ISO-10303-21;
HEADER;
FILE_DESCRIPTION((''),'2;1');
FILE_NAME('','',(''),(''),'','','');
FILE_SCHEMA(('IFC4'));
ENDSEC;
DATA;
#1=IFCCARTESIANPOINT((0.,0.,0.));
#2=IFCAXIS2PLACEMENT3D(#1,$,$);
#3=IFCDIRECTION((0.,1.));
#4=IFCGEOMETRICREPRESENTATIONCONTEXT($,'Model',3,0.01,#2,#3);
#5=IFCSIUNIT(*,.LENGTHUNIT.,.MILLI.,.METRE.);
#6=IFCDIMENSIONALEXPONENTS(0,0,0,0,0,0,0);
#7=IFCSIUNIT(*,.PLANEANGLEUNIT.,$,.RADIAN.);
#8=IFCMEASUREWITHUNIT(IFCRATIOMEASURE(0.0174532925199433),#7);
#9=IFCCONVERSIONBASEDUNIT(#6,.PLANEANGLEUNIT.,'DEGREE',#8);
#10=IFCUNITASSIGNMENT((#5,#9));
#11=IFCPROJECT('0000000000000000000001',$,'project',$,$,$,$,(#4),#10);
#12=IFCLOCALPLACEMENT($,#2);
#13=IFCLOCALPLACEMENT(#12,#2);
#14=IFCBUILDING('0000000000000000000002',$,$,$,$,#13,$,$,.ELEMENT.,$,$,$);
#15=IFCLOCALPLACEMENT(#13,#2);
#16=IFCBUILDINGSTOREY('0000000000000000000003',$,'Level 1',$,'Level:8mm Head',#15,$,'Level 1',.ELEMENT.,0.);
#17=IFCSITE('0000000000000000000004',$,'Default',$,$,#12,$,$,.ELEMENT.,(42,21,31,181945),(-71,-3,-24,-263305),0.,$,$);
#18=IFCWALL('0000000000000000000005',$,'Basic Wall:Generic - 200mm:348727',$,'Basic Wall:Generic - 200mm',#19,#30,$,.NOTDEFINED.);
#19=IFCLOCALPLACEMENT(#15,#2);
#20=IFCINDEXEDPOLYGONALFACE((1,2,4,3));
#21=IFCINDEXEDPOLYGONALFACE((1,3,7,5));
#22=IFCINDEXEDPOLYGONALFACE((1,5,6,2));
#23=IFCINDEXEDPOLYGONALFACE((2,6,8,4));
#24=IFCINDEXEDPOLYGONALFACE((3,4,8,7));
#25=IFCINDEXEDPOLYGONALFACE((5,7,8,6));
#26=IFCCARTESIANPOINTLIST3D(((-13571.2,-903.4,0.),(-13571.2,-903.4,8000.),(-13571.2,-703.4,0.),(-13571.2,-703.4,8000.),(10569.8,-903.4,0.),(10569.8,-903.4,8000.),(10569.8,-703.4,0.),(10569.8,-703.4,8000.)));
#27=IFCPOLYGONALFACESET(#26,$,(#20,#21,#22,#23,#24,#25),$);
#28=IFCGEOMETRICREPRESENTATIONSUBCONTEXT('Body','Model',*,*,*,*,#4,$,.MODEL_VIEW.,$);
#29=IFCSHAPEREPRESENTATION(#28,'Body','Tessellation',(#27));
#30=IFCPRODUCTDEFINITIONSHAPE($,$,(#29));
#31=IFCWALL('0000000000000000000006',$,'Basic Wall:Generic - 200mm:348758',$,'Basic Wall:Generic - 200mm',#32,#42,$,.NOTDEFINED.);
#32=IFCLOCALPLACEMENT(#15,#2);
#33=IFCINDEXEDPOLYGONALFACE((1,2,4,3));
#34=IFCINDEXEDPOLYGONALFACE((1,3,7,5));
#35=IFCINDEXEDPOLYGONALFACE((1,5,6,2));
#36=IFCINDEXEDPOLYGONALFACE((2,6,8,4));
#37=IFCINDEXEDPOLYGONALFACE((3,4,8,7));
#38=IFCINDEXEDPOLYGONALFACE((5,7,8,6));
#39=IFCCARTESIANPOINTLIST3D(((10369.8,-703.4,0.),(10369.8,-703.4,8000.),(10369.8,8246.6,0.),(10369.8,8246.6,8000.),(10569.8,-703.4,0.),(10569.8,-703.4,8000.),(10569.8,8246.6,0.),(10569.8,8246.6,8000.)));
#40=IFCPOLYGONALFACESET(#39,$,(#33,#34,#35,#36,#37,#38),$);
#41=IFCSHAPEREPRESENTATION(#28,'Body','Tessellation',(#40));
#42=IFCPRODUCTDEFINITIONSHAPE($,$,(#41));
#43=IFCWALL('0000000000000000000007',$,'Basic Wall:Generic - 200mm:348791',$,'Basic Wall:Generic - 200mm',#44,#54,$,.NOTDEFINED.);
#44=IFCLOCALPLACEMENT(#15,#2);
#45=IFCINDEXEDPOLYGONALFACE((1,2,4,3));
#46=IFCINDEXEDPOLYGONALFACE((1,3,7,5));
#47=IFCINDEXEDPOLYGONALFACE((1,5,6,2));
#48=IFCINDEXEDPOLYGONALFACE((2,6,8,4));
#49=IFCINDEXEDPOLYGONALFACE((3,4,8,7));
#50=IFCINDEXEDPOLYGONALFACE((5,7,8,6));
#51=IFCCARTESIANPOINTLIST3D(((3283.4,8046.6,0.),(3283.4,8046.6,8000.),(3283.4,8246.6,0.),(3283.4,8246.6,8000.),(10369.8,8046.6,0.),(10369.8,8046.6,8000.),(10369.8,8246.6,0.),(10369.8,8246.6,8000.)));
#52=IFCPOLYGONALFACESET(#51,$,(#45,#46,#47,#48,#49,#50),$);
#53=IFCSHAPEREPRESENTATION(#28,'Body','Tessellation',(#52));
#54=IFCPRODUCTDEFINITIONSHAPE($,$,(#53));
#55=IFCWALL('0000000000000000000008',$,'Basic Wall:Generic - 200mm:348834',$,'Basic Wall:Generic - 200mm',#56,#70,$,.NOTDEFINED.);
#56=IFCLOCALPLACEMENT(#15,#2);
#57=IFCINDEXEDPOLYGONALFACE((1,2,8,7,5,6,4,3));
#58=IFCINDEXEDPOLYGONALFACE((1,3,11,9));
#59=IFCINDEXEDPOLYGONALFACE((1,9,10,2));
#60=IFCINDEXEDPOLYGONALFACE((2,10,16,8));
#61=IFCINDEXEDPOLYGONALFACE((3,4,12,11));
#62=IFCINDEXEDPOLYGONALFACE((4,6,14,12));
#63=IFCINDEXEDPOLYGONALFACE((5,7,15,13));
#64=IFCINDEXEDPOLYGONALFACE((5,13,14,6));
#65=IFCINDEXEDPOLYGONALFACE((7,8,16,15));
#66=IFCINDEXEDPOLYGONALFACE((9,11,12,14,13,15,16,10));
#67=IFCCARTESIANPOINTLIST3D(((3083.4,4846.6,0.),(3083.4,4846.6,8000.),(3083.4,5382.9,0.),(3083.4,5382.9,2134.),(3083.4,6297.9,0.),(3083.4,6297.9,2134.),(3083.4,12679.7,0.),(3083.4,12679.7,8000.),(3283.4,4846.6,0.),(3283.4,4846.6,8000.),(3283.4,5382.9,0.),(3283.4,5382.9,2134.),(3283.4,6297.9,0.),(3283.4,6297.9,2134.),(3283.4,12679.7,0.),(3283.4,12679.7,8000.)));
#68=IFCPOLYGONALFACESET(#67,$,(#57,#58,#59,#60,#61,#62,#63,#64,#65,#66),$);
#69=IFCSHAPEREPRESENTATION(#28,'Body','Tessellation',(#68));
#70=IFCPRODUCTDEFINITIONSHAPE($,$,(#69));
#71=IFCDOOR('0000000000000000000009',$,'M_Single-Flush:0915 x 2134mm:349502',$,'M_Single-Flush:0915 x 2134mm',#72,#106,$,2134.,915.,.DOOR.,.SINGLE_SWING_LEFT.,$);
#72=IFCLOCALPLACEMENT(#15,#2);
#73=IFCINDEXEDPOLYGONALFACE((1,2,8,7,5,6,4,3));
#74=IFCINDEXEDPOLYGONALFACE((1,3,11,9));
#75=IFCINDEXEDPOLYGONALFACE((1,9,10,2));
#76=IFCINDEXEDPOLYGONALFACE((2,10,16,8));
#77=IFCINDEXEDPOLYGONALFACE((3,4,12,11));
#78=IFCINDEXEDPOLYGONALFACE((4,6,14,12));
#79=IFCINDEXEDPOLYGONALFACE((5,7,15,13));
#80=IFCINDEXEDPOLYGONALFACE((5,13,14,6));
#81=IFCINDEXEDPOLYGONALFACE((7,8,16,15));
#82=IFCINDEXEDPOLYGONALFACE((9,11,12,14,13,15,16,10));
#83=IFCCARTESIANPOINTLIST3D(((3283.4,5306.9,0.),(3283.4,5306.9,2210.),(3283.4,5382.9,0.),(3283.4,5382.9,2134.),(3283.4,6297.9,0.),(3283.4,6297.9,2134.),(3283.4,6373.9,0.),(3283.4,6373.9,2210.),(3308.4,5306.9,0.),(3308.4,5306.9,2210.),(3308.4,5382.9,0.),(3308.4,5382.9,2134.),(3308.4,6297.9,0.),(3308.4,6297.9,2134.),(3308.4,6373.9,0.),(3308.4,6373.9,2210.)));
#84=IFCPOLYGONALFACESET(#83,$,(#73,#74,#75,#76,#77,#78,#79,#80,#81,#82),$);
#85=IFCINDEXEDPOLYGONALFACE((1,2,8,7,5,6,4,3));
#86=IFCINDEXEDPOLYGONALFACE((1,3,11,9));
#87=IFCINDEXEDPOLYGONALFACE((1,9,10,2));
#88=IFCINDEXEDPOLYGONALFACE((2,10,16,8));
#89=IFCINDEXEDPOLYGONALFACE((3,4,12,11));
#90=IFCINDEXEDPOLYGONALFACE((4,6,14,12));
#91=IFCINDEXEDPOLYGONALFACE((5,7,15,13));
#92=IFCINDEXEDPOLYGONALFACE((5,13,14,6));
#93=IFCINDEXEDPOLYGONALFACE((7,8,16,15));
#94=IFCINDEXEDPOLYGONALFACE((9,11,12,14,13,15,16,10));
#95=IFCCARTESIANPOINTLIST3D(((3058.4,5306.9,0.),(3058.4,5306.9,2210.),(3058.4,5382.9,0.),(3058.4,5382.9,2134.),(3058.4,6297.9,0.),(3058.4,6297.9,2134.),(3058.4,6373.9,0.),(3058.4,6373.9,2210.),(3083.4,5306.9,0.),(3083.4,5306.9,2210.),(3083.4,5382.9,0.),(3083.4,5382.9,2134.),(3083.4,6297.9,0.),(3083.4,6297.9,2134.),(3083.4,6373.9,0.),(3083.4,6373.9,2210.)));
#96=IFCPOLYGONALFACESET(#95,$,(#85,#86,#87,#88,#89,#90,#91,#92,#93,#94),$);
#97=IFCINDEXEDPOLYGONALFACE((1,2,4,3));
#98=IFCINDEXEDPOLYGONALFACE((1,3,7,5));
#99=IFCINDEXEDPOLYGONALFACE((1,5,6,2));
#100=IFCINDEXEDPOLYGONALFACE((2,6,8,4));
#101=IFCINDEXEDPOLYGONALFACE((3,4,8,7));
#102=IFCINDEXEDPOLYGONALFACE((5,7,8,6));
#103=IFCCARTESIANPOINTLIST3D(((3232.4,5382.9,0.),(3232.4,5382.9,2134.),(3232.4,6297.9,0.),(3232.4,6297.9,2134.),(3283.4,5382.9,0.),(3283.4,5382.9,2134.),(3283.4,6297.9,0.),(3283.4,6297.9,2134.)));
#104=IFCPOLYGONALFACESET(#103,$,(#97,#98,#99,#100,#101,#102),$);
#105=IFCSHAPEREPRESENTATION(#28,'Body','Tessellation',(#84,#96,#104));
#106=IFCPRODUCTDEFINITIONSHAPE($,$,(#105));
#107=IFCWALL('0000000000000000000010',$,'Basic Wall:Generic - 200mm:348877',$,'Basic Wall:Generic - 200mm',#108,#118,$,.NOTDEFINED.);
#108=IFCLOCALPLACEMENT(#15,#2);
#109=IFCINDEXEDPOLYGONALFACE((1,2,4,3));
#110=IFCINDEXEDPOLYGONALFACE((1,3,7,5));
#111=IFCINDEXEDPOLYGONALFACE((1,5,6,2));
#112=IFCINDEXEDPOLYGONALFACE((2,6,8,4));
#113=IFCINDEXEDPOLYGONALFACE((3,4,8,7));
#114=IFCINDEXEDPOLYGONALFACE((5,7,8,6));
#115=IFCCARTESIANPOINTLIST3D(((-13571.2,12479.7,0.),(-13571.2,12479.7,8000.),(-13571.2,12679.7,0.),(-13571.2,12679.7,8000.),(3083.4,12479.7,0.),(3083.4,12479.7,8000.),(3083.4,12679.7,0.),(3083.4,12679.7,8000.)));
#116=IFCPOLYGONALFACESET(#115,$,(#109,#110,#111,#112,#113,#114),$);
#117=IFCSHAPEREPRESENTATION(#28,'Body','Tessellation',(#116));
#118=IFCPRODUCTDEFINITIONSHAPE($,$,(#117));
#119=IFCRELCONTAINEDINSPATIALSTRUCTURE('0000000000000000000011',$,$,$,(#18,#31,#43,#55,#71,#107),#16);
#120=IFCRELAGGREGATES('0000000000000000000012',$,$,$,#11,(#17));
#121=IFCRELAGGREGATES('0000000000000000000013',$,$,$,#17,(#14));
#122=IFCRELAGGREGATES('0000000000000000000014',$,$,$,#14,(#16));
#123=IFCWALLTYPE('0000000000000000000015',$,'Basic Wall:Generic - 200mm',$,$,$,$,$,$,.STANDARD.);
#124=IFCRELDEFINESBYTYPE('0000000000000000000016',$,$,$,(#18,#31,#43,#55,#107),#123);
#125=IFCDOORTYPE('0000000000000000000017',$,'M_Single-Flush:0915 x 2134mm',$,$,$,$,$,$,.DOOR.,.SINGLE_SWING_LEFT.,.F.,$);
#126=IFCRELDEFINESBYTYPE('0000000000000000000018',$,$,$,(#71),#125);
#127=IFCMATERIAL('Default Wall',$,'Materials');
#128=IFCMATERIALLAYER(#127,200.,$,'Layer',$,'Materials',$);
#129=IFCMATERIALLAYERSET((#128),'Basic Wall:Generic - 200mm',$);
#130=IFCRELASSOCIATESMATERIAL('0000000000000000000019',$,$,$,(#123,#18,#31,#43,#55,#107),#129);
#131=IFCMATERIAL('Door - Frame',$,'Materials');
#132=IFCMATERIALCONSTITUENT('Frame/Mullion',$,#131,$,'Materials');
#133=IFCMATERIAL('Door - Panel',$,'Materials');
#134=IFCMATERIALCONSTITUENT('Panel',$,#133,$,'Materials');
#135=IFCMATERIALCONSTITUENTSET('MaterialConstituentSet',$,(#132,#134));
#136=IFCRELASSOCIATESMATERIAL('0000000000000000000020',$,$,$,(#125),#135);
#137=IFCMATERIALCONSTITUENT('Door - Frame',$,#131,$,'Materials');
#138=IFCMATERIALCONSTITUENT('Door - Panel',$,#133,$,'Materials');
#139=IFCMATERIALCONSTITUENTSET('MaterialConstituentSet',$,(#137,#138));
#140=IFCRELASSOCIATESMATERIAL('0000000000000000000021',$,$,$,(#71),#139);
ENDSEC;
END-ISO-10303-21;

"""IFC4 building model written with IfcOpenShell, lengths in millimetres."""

from ifc_helpers import new_model, entity, si_unit, converted_unit, direction, frame, frame_2d, origin, place, context, subcontext, project, spatial, polyline, rectangle, outline, extrude, source, transform, mapped, material, layer, layer_set, layer_usage, constituent, constituent_set, type_object, type_shapes, element, fill, save


model = new_model("IFC4")

# Units and contexts
model_context = context("Model", 3, precision=0.01, world=origin(), true_north=direction((0.0, 1.0)))
body_context = subcontext(model_context, "Body", "Model", "MODEL_VIEW")
ifc_project = project(units=[si_unit("LENGTHUNIT", "METRE", prefix="MILLI"), converted_unit("PLANEANGLEUNIT", "DEGREE", entity("IfcRatioMeasure", 0.0174532925199433), si_unit("PLANEANGLEUNIT", "RADIAN"), dimensions=[0, 0, 0, 0, 0, 0, 0])], contexts=[model_context])

# Site, building, storey
site_placement = place(None, origin())
site = spatial("IfcSite", under=ifc_project, at=site_placement, Name="Default", CompositionType="ELEMENT", RefLatitude=(42, 21, 31, 181945), RefLongitude=(-71, -3, -24, -263305), RefElevation=0.0)
building_placement = place(site_placement, origin())
building = spatial("IfcBuilding", under=site, at=building_placement, CompositionType="ELEMENT")
storey_placement = place(building_placement, origin())
storey = spatial("IfcBuildingStorey", under=building, at=storey_placement, Name="Level 1", ObjectType="Level:8mm Head", LongName="Level 1", CompositionType="ELEMENT", Elevation=0.0)

# Walls
ifc_material_1 = material(Name="Default Wall", Category="Materials")
ifc_layer = layer(ifc_material_1, 200.0, Name="Layer", Category="Materials")
ifc_layer_set = layer_set([ifc_layer], Name="Basic Wall:Generic - 200mm")
ifc_layer_usage_1 = layer_usage(ifc_layer_set, "AXIS2", "NEGATIVE", 100.0)
wall_type = type_object("IfcWallType", Name="Basic Wall:Generic - 200mm", PredefinedType="STANDARD", material=ifc_layer_set)
wall_1_placement = place(storey_placement, frame((-13571.2, -803.4, 0.0)))
element("IfcWall", 1, at=wall_1_placement, inside=storey, type_object=wall_type, material=ifc_layer_usage_1, Name="Basic Wall:Generic - 200mm:348727", ObjectType="Basic Wall:Generic - 200mm", PredefinedType="NOTDEFINED", context=body_context, shape_type="SweptSolid", body=[
    extrude(rectangle(XDim=24141.0, YDim=200.0, at=frame_2d((12070.5, 0.0), x_axis=(-1.0, 0.0))), origin(), (0.0, 0.0, 1.0), 8000.0),
])
ifc_layer_usage_2 = layer_usage(ifc_layer_set, "AXIS2", "NEGATIVE", 100.0)
wall_2_placement = place(storey_placement, frame((10469.8, -703.4, 0.0), z_axis=(0.0, 0.0, 1.0), x_axis=(0.0, 1.0, 0.0)))
element("IfcWall", 2, at=wall_2_placement, inside=storey, type_object=wall_type, material=ifc_layer_usage_2, Name="Basic Wall:Generic - 200mm:348758", ObjectType="Basic Wall:Generic - 200mm", PredefinedType="NOTDEFINED", context=body_context, shape_type="SweptSolid", body=[
    extrude(rectangle(XDim=8950.0, YDim=200.0, at=frame_2d((4475.0, 0.0), x_axis=(-1.0, 0.0))), origin(), (0.0, 0.0, 1.0), 8000.0),
])
ifc_layer_usage_3 = layer_usage(ifc_layer_set, "AXIS2", "NEGATIVE", 100.0)
wall_3_placement = place(storey_placement, frame((10369.8, 8146.6, 0.0), z_axis=(0.0, 0.0, 1.0), x_axis=(-1.0, 0.0, 0.0)))
element("IfcWall", 3, at=wall_3_placement, inside=storey, type_object=wall_type, material=ifc_layer_usage_3, Name="Basic Wall:Generic - 200mm:348791", ObjectType="Basic Wall:Generic - 200mm", PredefinedType="NOTDEFINED", context=body_context, shape_type="SweptSolid", body=[
    extrude(rectangle(XDim=7086.4, YDim=200.0, at=frame_2d((3543.2, 0.0), x_axis=(-1.0, 0.0))), origin(), (0.0, 0.0, 1.0), 8000.0),
])

# Wall, opening, door
ifc_layer_usage_4 = layer_usage(ifc_layer_set, "AXIS2", "NEGATIVE", 100.0)
wall_4_placement = place(storey_placement, frame((3183.4, 4846.6, 0.0), z_axis=(0.0, 0.0, 1.0), x_axis=(0.0, 1.0, 0.0)))
wall_4 = element("IfcWall", 4, at=wall_4_placement, inside=storey, type_object=wall_type, material=ifc_layer_usage_4, Name="Basic Wall:Generic - 200mm:348834", ObjectType="Basic Wall:Generic - 200mm", PredefinedType="NOTDEFINED", context=body_context, shape_type="SweptSolid", body=[
    extrude(rectangle(XDim=7833.1, YDim=200.0, at=frame_2d((3916.6, 0.0), x_axis=(-1.0, 0.0))), origin(), (0.0, 0.0, 1.0), 8000.0),
])
opening_1_placement = place(wall_4_placement, frame((1451.3, 100.0, 0.0)))
opening_1 = element("IfcOpeningElement", 5, at=opening_1_placement, cuts=wall_4, PredefinedType="OPENING", context=body_context, shape_type="SweptSolid", body=[
    extrude(rectangle(XDim=915.0, YDim=2134.0, at=frame_2d((1067.0, 457.5), x_axis=(0.0, -1.0))), frame((0.0, 0.0, 0.0), z_axis=(0.0, -1.0, 0.0), x_axis=(0.0, 0.0, 1.0)), (0.0, 0.0, 1.0), 200.0),
])
ifc_material_2 = material(Name="Door - Frame", Category="Materials")
ifc_constituent_1 = constituent(ifc_material_2, Name="Door - Frame", Category="Materials")
ifc_material_3 = material(Name="Door - Panel", Category="Materials")
ifc_constituent_2 = constituent(ifc_material_3, Name="Door - Panel", Category="Materials")
ifc_constituent_set_1 = constituent_set(constituents=[ifc_constituent_1, ifc_constituent_2], Name="MaterialConstituentSet")
ifc_constituent_3 = constituent(ifc_material_2, Name="Frame/Mullion", Category="Materials")
ifc_constituent_4 = constituent(ifc_material_3, Name="Panel", Category="Materials")
ifc_constituent_set_2 = constituent_set(constituents=[ifc_constituent_3, ifc_constituent_4], Name="MaterialConstituentSet")
door_type_1 = type_object("IfcDoorType", Name="M_Single-Flush:0915 x 2134mm", OperationType="SINGLE_SWING_LEFT", ParameterTakesPrecedence=False, PredefinedType="DOOR", material=ifc_constituent_set_2)
shared_shape_1 = source(origin(), body_context, "Body", "SweptSolid", [
    extrude(outline(polyline([(-533.5, -1124.0), (533.5, -1124.0), (533.5, 1086.0), (457.5, 1086.0), (457.5, -1048.0), (-457.5, -1048.0), (-457.5, 1086.0), (-533.5, 1086.0), (-533.5, -1124.0)])), frame((457.5, 225.0, 1086.0), z_axis=(0.0, -1.0, 0.0), x_axis=(-1.0, 0.0, 0.0)), (0.0, 0.0, 1.0), 25.0),
    extrude(outline(polyline([(-1124.0, -533.5), (1086.0, -533.5), (1086.0, -457.5), (-1048.0, -457.5), (-1048.0, 457.5), (1086.0, 457.5), (1086.0, 533.5), (-1124.0, 533.5), (-1124.0, -533.5)])), frame((457.5, 0.0, 1086.0), z_axis=(0.0, -1.0, 0.0), x_axis=(0.0, 0.0, -1.0)), (0.0, 0.0, 1.0), 25.0),
    extrude(rectangle(XDim=915.0, YDim=51.0, at=frame_2d((0.0, 0.0), x_axis=(1.0, 0.0))), frame((457.5, 174.5, 0.0)), (0.0, 0.0, 1.0), 2134.0),
])
type_shapes(door_type_1, [shared_shape_1])
door_1_placement = place(opening_1_placement, frame((0.0, 0.0, 0.0), z_axis=(0.0, 0.0, 1.0), x_axis=(-1.0, 0.0, 0.0)))
door_1 = element("IfcDoor", 6, at=door_1_placement, inside=storey, type_object=door_type_1, material=ifc_constituent_set_1, Name="M_Single-Flush:0915 x 2134mm:349502", ObjectType="M_Single-Flush:0915 x 2134mm", OperationType="SINGLE_SWING_LEFT", OverallHeight=2134.0, OverallWidth=915.0, PredefinedType="DOOR", context=body_context, shape_type="MappedRepresentation", body=[
    mapped(shared_shape_1, transform((0.0, 0.0, 0.0), scale=1.0)),
])
fill(opening_1, door_1)

# Wall
ifc_layer_usage_5 = layer_usage(ifc_layer_set, "AXIS2", "NEGATIVE", 100.0)
wall_5_placement = place(storey_placement, frame((3083.4, 12579.7, 0.0), z_axis=(0.0, 0.0, 1.0), x_axis=(-1.0, 0.0, 0.0)))
element("IfcWall", 7, at=wall_5_placement, inside=storey, type_object=wall_type, material=ifc_layer_usage_5, Name="Basic Wall:Generic - 200mm:348877", ObjectType="Basic Wall:Generic - 200mm", PredefinedType="NOTDEFINED", context=body_context, shape_type="SweptSolid", body=[
    extrude(rectangle(XDim=16654.6, YDim=200.0, at=frame_2d((8327.3, 0.0), x_axis=(-1.0, 0.0))), origin(), (0.0, 0.0, 1.0), 8000.0),
])

save(model, "model.ifc")
